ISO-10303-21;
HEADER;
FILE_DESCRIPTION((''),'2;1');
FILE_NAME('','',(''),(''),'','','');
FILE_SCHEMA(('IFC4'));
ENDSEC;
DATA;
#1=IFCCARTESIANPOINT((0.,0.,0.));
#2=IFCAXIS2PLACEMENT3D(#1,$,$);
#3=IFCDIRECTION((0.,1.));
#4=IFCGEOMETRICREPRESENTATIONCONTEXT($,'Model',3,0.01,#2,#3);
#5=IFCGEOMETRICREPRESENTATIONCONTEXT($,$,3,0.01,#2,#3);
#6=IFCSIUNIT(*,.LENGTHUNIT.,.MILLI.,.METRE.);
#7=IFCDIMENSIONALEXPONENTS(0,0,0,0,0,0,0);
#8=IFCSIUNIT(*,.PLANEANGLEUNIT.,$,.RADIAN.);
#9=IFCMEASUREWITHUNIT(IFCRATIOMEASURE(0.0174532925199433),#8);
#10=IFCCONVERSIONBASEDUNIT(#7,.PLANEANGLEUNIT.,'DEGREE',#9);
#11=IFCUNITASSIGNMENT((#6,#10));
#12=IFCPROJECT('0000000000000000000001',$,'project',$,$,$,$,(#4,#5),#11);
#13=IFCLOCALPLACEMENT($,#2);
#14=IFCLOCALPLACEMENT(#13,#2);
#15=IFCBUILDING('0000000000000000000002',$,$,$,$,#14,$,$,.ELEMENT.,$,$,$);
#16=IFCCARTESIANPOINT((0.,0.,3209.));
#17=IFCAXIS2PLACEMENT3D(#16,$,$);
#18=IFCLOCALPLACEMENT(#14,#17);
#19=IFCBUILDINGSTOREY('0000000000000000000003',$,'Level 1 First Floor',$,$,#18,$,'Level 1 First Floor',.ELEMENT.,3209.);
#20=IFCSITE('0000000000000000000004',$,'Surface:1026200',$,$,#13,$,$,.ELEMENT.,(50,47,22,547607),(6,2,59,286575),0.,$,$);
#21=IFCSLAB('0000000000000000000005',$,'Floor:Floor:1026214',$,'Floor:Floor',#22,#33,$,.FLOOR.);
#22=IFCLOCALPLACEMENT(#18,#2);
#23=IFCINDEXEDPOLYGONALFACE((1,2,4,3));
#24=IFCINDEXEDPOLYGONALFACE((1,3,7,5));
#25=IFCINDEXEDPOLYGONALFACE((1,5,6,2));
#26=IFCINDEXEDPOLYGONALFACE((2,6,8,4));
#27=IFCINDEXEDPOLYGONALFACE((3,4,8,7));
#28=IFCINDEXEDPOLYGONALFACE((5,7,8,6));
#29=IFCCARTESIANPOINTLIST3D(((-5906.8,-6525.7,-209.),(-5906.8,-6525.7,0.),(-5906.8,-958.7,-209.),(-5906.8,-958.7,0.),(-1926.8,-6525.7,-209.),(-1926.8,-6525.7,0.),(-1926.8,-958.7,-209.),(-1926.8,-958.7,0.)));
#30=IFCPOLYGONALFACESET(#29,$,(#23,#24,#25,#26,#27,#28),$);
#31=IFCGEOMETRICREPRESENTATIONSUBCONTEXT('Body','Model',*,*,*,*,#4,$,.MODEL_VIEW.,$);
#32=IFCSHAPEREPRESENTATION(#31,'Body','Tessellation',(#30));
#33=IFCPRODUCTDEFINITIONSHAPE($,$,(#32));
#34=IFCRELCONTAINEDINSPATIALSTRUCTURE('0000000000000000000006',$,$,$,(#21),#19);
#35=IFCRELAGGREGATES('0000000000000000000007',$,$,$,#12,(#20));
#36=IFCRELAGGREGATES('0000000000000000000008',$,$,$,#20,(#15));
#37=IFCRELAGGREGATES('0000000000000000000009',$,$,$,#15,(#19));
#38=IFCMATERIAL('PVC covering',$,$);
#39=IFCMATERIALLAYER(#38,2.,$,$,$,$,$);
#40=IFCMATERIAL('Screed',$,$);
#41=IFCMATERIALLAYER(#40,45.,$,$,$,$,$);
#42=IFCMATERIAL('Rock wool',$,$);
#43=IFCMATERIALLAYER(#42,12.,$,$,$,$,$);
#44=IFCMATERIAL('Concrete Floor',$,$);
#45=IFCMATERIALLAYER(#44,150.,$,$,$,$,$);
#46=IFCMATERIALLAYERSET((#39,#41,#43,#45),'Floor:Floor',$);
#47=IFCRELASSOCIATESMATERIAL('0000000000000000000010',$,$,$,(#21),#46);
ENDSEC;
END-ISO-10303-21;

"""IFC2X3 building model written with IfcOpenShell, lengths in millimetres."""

from ifc_helpers import new_model, entity, si_unit, converted_unit, direction, frame, frame_2d, origin, place, context, subcontext, project, spatial, rectangle, extrude, material, layer, layer_set, layer_usage, element, save


model = new_model("IFC2X3")

# Units and contexts
model_context = context("Model", 3, precision=0.01, world=origin(), true_north=direction((0.0, 1.0)))
context_of_model = context(None, 3, precision=0.01, world=origin(), true_north=direction((0.0, 1.0)))
body_context = subcontext(model_context, "Body", "Model", "MODEL_VIEW")
ifc_project = project(units=[si_unit("LENGTHUNIT", "METRE", prefix="MILLI"), converted_unit("PLANEANGLEUNIT", "DEGREE", entity("IfcRatioMeasure", 0.0174532925199433), si_unit("PLANEANGLEUNIT", "RADIAN"), dimensions=[0, 0, 0, 0, 0, 0, 0])], contexts=[model_context, context_of_model])

# Site, building, storey
site_placement = place(None, origin())
site = spatial("IfcSite", under=ifc_project, at=site_placement, Name="Surface:1026200", CompositionType="ELEMENT", RefLatitude=(50, 47, 22, 547607), RefLongitude=(6, 2, 59, 286575), RefElevation=0.0)
building_placement = place(site_placement, origin())
building = spatial("IfcBuilding", under=site, at=building_placement, CompositionType="ELEMENT")
storey_placement = place(building_placement, frame((0.0, 0.0, 3209.0)))
storey = spatial("IfcBuildingStorey", under=building, at=storey_placement, Name="Level 1 First Floor", LongName="Level 1 First Floor", CompositionType="ELEMENT", Elevation=3209.0)

# Slab
ifc_material_1 = material(Name="PVC covering")
ifc_layer_1 = layer(ifc_material_1, 2.0)
ifc_material_2 = material(Name="Screed")
ifc_layer_2 = layer(ifc_material_2, 45.0)
ifc_material_3 = material(Name="Rock wool")
ifc_layer_3 = layer(ifc_material_3, 12.0)
ifc_material_4 = material(Name="Concrete Floor")
ifc_layer_4 = layer(ifc_material_4, 150.0)
ifc_layer_set = layer_set([ifc_layer_1, ifc_layer_2, ifc_layer_3, ifc_layer_4], Name="Floor:Floor")
ifc_layer_usage = layer_usage(ifc_layer_set, "AXIS3", "POSITIVE", 0.0)
slab_placement = place(storey_placement, origin())
element("IfcSlab", 1, at=slab_placement, inside=storey, material=ifc_layer_usage, Name="Floor:Floor:1026214", ObjectType="Floor:Floor", PredefinedType="FLOOR", context=body_context, shape_type="SweptSolid", body=[
    extrude(rectangle(XDim=5567.0, YDim=3980.0, at=frame_2d((0.0, 0.0), x_axis=(1.0, 0.0))), frame((-3916.8, -3742.2, 0.0), z_axis=(0.0, 0.0, -1.0), x_axis=(0.0, 1.0, 0.0)), (0.0, 0.0, 1.0), 209.0),
])

save(model, "model.ifc")
